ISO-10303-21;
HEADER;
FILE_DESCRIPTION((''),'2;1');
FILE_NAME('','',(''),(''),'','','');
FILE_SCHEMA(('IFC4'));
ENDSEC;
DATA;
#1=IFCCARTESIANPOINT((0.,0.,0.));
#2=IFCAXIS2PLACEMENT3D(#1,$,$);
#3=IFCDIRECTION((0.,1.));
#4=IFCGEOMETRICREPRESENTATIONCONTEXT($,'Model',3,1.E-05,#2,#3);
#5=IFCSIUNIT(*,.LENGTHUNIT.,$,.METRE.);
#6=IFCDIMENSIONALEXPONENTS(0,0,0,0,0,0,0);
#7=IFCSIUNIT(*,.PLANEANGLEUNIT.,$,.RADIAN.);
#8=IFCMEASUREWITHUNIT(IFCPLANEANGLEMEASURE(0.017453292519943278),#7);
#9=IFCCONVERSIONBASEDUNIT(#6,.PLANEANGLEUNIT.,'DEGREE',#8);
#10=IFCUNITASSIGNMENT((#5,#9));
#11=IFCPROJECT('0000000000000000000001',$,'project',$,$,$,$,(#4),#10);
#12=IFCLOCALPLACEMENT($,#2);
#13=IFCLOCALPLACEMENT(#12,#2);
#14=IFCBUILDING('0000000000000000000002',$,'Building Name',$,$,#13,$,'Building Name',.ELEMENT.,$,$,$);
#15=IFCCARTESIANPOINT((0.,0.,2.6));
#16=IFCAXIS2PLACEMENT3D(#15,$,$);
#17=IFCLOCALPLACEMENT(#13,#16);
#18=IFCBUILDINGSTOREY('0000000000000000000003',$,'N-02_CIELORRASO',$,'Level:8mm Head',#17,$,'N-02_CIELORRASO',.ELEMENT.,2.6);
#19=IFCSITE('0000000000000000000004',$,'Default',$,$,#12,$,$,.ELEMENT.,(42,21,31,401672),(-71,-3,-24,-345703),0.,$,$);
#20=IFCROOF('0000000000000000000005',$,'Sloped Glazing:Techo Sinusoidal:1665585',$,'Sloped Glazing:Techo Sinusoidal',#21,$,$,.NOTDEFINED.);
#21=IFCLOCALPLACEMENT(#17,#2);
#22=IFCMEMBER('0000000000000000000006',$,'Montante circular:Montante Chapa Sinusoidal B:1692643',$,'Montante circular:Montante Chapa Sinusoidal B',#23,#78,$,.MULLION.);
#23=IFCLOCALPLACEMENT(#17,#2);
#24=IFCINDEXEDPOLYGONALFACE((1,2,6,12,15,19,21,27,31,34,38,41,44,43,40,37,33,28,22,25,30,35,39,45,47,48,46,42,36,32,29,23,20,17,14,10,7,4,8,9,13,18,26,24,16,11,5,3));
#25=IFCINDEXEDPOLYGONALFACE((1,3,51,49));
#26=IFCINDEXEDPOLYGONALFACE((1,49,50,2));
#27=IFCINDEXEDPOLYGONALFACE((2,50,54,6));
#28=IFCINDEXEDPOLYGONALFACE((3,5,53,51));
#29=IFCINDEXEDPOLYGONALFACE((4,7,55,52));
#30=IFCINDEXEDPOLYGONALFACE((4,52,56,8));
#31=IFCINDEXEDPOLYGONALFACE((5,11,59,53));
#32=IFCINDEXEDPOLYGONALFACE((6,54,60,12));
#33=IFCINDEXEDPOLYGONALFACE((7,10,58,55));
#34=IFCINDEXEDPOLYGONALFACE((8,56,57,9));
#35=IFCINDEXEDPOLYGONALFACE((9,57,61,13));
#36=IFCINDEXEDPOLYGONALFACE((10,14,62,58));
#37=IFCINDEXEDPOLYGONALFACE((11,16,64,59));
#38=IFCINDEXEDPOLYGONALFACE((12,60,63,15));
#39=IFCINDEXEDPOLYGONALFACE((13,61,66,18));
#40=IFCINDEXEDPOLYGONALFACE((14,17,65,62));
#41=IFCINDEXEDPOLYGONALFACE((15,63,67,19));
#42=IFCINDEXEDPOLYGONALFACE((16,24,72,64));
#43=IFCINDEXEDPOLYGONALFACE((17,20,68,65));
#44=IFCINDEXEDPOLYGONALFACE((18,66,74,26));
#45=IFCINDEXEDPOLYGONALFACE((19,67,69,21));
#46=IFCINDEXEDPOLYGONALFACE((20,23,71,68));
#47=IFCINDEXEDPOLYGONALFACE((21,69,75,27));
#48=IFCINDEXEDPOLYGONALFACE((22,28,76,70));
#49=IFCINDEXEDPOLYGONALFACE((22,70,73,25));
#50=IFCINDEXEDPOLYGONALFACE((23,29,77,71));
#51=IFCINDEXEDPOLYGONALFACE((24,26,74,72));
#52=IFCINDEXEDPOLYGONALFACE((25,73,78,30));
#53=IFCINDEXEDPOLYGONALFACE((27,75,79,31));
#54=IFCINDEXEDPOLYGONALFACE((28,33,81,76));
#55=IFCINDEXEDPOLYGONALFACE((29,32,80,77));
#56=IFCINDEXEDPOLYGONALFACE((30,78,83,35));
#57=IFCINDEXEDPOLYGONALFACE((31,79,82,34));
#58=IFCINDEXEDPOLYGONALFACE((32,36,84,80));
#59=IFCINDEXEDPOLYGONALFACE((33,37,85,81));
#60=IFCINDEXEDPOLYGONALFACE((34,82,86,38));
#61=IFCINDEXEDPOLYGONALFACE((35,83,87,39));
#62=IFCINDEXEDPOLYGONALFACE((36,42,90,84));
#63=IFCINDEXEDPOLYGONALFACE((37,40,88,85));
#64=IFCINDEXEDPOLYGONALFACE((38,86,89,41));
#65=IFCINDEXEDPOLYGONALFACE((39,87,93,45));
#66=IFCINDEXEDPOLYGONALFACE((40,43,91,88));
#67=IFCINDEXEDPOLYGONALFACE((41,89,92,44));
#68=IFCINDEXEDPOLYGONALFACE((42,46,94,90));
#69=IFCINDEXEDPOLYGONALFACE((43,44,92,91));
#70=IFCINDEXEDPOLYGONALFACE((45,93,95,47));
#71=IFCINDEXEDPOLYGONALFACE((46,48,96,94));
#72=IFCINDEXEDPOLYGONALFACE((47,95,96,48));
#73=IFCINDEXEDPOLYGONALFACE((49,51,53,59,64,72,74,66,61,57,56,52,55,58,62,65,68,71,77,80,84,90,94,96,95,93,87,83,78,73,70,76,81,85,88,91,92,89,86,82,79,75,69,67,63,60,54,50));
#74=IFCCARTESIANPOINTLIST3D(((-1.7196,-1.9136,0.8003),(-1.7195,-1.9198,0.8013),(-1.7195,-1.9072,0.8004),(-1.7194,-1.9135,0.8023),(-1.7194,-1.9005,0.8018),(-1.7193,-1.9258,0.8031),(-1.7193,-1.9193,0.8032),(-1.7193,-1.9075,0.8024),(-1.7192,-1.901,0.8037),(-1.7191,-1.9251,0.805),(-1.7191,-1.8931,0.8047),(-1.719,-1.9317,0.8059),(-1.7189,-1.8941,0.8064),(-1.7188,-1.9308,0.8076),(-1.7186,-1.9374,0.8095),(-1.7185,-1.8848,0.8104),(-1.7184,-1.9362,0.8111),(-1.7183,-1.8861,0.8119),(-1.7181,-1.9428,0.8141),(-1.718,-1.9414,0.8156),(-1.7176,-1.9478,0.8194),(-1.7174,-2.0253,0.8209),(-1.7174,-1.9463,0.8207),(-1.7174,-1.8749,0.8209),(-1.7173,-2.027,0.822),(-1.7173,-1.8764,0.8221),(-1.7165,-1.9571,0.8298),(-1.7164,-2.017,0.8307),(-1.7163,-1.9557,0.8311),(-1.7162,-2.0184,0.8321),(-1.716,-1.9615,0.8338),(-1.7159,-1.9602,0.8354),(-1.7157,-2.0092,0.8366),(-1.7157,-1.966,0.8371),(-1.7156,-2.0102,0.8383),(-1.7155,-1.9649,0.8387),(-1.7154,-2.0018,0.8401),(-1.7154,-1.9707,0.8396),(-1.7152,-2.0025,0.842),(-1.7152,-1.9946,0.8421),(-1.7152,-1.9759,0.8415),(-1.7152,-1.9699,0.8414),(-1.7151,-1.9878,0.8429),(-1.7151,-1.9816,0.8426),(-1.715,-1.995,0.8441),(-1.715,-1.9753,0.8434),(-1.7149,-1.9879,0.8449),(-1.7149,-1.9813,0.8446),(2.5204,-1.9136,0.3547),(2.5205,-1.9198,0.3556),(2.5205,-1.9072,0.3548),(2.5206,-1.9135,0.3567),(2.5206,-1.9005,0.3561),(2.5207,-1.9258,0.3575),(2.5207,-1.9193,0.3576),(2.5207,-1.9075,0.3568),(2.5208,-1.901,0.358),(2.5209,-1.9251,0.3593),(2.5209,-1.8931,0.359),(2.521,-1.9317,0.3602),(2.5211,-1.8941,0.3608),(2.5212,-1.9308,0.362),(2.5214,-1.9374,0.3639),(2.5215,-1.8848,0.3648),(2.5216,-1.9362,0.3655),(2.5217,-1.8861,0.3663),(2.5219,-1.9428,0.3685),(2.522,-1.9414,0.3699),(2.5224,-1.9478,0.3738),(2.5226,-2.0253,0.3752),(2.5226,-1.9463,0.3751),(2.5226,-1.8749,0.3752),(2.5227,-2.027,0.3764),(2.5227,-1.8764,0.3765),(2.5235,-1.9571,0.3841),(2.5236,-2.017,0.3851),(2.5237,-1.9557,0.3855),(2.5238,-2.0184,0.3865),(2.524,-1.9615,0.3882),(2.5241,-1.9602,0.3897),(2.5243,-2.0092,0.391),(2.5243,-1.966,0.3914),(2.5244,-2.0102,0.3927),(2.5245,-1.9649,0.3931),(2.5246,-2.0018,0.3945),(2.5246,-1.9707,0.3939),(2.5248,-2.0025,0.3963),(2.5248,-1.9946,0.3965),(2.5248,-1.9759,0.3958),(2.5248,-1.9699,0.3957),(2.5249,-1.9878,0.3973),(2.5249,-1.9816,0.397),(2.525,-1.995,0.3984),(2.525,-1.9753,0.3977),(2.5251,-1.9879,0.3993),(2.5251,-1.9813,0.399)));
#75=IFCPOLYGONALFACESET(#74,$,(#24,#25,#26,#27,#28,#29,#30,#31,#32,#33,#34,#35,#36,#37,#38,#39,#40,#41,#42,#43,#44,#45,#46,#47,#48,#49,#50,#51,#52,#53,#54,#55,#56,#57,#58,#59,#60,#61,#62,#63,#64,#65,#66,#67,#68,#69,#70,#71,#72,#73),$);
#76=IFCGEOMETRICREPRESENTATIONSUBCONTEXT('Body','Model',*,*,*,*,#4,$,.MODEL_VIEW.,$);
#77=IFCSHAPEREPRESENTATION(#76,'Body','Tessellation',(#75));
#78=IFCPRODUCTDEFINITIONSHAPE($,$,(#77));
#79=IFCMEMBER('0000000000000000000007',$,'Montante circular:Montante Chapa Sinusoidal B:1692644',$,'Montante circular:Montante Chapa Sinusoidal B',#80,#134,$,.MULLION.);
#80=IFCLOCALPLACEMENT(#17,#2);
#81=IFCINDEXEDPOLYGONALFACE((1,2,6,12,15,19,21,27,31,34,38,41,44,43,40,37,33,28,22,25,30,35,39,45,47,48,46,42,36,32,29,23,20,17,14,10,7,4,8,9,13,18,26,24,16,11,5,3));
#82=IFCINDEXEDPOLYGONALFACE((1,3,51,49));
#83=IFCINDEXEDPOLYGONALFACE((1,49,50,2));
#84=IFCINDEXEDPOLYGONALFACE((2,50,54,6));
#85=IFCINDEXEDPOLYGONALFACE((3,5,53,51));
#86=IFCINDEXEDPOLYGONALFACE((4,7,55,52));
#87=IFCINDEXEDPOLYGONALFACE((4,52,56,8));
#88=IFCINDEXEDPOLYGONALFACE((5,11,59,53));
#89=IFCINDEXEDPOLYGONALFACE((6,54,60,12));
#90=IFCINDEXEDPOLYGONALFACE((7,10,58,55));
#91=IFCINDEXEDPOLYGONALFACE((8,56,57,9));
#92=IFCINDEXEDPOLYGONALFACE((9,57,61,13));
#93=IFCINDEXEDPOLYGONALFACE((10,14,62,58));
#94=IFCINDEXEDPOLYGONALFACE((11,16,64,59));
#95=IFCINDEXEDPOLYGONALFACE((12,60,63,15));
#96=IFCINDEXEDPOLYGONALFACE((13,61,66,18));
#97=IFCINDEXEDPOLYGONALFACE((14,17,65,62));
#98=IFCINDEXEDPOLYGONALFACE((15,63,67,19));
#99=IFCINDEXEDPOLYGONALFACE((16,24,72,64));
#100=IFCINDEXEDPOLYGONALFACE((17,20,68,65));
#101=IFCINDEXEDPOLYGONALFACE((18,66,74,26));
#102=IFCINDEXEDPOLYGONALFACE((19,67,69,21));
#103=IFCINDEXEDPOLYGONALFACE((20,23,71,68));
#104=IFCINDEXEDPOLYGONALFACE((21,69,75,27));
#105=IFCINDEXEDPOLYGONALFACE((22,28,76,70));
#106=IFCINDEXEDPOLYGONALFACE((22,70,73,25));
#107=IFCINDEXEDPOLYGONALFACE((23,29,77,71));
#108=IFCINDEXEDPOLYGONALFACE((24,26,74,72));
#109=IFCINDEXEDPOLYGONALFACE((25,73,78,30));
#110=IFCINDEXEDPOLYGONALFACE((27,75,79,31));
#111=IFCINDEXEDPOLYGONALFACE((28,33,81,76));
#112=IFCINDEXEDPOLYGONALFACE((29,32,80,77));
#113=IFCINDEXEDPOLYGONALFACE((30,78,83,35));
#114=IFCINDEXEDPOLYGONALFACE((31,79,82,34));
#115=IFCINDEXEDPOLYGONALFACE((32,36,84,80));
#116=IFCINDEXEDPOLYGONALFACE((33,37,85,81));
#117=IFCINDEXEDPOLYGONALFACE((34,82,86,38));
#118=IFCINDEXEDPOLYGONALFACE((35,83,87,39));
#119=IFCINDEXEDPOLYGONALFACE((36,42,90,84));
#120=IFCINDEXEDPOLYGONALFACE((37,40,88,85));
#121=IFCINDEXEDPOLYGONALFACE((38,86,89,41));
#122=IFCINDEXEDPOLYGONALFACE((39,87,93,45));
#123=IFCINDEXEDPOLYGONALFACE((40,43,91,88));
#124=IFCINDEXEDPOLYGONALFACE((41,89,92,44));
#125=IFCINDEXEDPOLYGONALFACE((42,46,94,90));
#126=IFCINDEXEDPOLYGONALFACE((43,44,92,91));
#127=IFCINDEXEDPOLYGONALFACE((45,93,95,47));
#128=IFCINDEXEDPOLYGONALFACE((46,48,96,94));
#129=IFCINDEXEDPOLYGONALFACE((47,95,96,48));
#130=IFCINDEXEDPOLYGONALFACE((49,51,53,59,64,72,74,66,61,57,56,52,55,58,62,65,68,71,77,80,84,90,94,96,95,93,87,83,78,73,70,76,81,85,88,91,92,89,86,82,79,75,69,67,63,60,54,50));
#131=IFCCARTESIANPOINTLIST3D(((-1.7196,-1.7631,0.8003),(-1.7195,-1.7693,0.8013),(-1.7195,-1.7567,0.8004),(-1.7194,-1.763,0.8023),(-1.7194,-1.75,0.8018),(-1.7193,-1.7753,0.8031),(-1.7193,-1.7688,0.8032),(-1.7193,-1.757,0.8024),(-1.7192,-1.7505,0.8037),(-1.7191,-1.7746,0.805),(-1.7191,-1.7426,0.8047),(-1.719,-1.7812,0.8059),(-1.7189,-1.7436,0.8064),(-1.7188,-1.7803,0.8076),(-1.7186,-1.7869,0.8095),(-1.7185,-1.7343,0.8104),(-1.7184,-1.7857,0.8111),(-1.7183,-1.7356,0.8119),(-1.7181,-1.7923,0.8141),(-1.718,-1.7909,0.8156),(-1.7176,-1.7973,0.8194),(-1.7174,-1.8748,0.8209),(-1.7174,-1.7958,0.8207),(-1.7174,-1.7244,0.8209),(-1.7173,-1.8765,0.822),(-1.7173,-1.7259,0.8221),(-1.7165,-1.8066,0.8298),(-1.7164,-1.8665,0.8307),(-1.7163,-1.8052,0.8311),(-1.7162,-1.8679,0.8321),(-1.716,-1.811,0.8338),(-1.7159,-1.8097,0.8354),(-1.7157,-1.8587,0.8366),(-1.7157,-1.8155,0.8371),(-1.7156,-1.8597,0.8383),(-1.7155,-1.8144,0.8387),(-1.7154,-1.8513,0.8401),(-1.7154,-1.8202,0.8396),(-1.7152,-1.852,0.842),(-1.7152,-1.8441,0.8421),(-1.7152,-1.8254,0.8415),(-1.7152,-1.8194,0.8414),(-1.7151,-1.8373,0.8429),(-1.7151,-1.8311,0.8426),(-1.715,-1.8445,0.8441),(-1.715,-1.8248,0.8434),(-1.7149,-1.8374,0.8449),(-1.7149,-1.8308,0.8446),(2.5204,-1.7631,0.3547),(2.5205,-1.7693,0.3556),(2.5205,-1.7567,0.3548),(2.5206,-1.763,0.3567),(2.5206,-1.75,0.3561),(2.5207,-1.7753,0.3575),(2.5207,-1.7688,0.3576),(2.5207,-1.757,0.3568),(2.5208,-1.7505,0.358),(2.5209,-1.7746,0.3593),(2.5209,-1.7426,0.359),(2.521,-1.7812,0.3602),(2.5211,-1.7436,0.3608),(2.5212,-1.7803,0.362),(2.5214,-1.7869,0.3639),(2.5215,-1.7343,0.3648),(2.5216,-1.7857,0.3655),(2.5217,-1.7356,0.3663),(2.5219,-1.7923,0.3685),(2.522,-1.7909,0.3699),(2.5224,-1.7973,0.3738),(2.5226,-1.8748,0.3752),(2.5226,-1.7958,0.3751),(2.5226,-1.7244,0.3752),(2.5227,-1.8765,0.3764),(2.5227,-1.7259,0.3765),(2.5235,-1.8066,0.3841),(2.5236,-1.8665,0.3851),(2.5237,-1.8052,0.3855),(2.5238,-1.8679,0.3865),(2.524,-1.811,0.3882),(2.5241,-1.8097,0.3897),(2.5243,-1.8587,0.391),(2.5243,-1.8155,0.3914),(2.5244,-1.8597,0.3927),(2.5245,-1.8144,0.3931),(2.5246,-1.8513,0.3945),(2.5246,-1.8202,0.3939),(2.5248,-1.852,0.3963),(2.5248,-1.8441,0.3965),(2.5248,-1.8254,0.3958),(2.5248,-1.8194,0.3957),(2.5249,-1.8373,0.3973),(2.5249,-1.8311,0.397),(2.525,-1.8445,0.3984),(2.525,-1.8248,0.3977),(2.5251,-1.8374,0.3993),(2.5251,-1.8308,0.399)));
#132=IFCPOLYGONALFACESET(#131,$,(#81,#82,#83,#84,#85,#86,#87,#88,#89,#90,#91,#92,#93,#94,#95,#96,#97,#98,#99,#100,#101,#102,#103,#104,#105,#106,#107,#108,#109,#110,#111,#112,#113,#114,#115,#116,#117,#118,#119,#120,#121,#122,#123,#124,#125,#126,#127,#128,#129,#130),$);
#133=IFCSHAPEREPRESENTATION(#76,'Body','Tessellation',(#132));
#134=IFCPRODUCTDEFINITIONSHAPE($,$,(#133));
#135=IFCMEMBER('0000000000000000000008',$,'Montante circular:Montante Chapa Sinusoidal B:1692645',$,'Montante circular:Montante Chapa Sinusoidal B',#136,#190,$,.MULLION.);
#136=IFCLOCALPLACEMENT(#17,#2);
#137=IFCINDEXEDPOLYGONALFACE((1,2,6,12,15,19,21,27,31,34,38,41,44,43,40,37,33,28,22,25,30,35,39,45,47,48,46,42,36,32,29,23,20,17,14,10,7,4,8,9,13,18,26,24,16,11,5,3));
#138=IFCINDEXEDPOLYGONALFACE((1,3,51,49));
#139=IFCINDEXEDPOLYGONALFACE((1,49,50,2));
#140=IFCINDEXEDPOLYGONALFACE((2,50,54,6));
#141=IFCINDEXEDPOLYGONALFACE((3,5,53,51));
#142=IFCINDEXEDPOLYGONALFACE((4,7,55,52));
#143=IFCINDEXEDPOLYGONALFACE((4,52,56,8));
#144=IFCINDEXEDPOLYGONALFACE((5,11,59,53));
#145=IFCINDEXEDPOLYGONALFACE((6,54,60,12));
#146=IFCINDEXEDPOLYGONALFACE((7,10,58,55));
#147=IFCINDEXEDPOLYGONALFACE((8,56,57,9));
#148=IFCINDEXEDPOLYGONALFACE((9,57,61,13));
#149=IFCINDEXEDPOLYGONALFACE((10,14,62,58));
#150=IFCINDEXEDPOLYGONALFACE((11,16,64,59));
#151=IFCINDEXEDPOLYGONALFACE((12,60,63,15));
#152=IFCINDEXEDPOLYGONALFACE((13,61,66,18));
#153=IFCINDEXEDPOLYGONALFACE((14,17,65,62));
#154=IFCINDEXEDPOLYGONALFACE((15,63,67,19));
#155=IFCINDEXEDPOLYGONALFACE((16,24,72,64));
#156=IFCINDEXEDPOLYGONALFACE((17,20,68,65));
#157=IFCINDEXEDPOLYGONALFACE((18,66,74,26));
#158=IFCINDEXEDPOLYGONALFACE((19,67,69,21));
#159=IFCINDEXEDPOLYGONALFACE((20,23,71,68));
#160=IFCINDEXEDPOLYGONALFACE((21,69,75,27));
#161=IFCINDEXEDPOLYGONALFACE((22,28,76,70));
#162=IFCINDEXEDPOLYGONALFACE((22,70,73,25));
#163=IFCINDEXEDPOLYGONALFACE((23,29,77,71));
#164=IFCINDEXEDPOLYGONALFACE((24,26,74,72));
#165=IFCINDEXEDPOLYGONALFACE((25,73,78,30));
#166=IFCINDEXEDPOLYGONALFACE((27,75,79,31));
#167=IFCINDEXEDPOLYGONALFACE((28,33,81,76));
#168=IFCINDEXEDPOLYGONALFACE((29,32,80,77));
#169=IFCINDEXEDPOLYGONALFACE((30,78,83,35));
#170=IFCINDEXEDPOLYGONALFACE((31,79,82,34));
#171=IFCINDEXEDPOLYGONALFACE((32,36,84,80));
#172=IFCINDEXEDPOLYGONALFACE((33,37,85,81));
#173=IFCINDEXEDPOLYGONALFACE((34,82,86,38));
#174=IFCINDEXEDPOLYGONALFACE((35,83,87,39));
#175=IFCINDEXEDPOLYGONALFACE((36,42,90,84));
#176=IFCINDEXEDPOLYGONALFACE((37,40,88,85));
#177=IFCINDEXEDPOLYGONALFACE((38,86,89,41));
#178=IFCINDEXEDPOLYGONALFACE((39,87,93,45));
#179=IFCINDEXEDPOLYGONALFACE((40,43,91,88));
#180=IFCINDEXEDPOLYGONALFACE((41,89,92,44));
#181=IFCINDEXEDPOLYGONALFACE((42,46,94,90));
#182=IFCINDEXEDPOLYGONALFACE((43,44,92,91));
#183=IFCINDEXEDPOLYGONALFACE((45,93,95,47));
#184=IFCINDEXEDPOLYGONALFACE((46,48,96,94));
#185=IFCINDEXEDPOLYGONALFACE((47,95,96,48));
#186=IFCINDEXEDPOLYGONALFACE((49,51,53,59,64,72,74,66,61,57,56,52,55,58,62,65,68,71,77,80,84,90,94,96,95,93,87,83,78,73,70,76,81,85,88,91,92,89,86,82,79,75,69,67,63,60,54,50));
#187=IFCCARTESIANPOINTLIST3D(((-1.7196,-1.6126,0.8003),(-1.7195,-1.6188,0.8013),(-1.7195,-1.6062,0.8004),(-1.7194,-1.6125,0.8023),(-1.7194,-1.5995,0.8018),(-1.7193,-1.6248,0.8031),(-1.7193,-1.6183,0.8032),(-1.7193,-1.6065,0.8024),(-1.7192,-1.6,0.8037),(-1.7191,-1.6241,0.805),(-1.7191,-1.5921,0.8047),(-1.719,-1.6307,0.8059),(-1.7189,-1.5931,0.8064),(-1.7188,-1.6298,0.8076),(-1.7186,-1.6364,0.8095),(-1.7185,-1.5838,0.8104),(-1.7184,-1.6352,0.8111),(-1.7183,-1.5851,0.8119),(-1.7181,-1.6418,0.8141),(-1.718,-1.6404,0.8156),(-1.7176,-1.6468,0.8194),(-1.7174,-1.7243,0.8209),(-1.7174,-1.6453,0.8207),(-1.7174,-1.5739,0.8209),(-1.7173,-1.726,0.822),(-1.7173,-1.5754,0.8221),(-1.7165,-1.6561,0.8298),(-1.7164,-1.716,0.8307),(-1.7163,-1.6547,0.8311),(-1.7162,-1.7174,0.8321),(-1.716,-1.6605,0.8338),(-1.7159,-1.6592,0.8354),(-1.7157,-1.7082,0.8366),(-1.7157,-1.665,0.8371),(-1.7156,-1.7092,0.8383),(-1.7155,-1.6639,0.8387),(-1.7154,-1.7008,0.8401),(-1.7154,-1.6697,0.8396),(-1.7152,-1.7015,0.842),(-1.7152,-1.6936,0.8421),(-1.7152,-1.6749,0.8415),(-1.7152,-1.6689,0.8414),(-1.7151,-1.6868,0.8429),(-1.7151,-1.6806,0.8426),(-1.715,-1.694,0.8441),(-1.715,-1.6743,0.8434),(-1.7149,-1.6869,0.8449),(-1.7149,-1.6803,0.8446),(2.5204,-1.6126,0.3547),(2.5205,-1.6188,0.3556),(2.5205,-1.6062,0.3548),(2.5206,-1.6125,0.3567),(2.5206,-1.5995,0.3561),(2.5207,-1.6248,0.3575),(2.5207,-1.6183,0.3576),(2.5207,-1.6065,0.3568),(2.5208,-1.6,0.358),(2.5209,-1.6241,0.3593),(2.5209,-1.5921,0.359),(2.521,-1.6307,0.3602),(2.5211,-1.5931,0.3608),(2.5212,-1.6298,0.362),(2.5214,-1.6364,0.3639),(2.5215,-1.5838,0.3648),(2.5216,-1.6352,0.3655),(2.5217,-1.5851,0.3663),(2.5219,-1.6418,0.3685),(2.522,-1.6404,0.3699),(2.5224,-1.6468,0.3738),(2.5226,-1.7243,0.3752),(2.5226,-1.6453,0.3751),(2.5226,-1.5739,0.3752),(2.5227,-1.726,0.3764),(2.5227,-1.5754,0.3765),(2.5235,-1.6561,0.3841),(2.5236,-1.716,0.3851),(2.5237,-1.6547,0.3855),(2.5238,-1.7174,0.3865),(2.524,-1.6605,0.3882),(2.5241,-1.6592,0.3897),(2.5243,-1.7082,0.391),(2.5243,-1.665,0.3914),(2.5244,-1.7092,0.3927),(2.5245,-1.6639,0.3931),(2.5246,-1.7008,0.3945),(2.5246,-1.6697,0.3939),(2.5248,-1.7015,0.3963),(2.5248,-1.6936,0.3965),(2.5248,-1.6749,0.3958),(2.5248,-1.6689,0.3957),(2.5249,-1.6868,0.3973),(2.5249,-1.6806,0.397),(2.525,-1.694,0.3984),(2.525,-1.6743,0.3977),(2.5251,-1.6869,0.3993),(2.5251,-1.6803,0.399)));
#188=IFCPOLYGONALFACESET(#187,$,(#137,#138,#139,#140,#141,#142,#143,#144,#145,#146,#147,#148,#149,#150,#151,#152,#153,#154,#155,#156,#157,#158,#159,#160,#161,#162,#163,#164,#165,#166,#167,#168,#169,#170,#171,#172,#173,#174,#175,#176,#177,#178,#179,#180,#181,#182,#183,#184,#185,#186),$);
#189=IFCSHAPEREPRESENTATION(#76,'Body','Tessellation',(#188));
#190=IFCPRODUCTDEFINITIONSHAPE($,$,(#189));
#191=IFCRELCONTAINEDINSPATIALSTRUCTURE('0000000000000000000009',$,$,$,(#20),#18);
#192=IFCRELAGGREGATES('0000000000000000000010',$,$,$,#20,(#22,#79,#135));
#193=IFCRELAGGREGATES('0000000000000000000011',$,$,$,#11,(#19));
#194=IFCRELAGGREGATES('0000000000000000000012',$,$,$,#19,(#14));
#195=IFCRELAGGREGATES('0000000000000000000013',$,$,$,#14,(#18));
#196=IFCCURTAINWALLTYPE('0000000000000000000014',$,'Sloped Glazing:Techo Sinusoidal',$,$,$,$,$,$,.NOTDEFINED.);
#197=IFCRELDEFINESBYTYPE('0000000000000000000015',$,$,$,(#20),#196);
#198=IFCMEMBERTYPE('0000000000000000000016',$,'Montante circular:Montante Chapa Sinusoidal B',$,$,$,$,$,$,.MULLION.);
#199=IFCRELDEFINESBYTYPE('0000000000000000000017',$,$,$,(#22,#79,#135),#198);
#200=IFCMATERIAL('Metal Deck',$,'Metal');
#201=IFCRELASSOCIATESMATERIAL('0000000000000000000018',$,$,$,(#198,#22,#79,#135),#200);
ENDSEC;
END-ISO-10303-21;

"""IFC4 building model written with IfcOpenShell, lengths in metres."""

from ifc_helpers import new_model, entity, si_unit, converted_unit, direction, frame, origin, place, context, subcontext, project, spatial, indexed_curve, outline, extrude, source, transform, mapped, material, type_object, type_shapes, element, aggregate, save


model = new_model("IFC4")

# Units and contexts
model_context = context("Model", 3, precision=1e-05, world=origin(), true_north=direction((0.0, 1.0)))
body_context = subcontext(model_context, "Body", "Model", "MODEL_VIEW")
ifc_project = project(units=[si_unit("LENGTHUNIT", "METRE"), converted_unit("PLANEANGLEUNIT", "DEGREE", entity("IfcPlaneAngleMeasure", 0.017453292519943278), si_unit("PLANEANGLEUNIT", "RADIAN"), dimensions=[0, 0, 0, 0, 0, 0, 0])], contexts=[model_context])

# Site, building, storey
site_placement = place(None, origin())
site = spatial("IfcSite", under=ifc_project, at=site_placement, Name="Default", CompositionType="ELEMENT", RefLatitude=(42, 21, 31, 401672), RefLongitude=(-71, -3, -24, -345703), RefElevation=0.0)
building_placement = place(site_placement, origin())
building = spatial("IfcBuilding", under=site, at=building_placement, Name="Building Name", LongName="Building Name", CompositionType="ELEMENT")
storey_placement = place(building_placement, frame((0.0, 0.0, 2.6)))
storey = spatial("IfcBuildingStorey", under=building, at=storey_placement, Name="N-02_CIELORRASO", ObjectType="Level:8mm Head", LongName="N-02_CIELORRASO", CompositionType="ELEMENT", Elevation=2.6)

# Roof, members
curtain_wall_type = type_object("IfcCurtainWallType", Name="Sloped Glazing:Techo Sinusoidal", PredefinedType="NOTDEFINED")
roof_placement = place(storey_placement, frame((0.0, 0.0, -2.6)))
roof = element("IfcRoof", 1, at=roof_placement, inside=storey, type_object=curtain_wall_type, Name="Sloped Glazing:Techo Sinusoidal:1665585", ObjectType="Sloped Glazing:Techo Sinusoidal", PredefinedType="NOTDEFINED")
ifc_material_1 = material(Name="Metal Deck", Category="Metal")
member_type = type_object("IfcMemberType", Name="Montante circular:Montante Chapa Sinusoidal B", PredefinedType="MULLION", material=ifc_material_1)
shared_shape_1 = source(origin(), body_context, "Body", "SweptSolid", [
    extrude(outline(indexed_curve([(0.0595, -0.0443), (0.0615, -0.0443), (0.0603, -0.031), (0.0572, -0.0213), (0.053, -0.0138), (0.0481, -0.0078), (0.0427, -0.003), (0.0372, 0.0005), (0.0315, 0.0029), (0.0259, 0.0044), (0.0203, 0.0051), (0.0146, 0.005), (0.0084, 0.0041), (-0.0053, 0.0009), (-0.0123, -0.0005), (-0.0191, -0.0012), (-0.0256, -0.001), (-0.0317, 0.0001), (-0.0375, 0.0019), (-0.0428, 0.0046), (-0.0477, 0.0081), (-0.0522, 0.0128), (-0.0563, 0.0191), (-0.0597, 0.0282), (-0.0617, 0.0421), (-0.0637, 0.042), (-0.0616, 0.0277), (-0.0581, 0.0182), (-0.0537, 0.0116), (-0.049, 0.0066), (-0.0438, 0.0028), (-0.0382, 0.0001), (-0.0322, -0.0019), (-0.0258, -0.003), (-0.019, -0.0032), (-0.012, -0.0025), (-0.0048, -0.0011), (0.0088, 0.0021), (0.0147, 0.003), (0.0202, 0.0031), (0.0255, 0.0024), (0.0309, 0.001), (0.0362, -0.0013), (0.0415, -0.0046), (0.0466, -0.0092), (0.0513, -0.0149), (0.0554, -0.0221), (0.0584, -0.0314), (0.0595, -0.0443)], self_intersect=False)), frame((-0.007, 0.0228, -4.2634), z_axis=(0.0, 0.0, 1.0), x_axis=(-0.819152, -0.573576, 0.0)), (0.0, 0.0, 1.0), 4.2634),
])
type_shapes(member_type, [shared_shape_1])
member_1_placement = place(roof_placement, frame((-1.7148, -1.9441, 3.4456), z_axis=(-0.994522, 0.0, 0.104528), x_axis=(0.0, 1.0, 0.0)))
member_1 = element("IfcMember", 2, at=member_1_placement, type_object=member_type, material=ifc_material_1, Name="Montante circular:Montante Chapa Sinusoidal B:1692643", ObjectType="Montante circular:Montante Chapa Sinusoidal B", PredefinedType="MULLION", context=body_context, shape_type="MappedRepresentation", body=[
    mapped(shared_shape_1, transform((0.0, 0.0, 0.0), scale=1.0)),
])
member_2_placement = place(roof_placement, frame((-1.7148, -1.7936, 3.4456), z_axis=(-0.994522, 0.0, 0.104528), x_axis=(0.0, 1.0, 0.0)))
member_2 = element("IfcMember", 3, at=member_2_placement, type_object=member_type, material=ifc_material_1, Name="Montante circular:Montante Chapa Sinusoidal B:1692644", ObjectType="Montante circular:Montante Chapa Sinusoidal B", PredefinedType="MULLION", context=body_context, shape_type="MappedRepresentation", body=[
    mapped(shared_shape_1, transform((0.0, 0.0, 0.0), scale=1.0)),
])
member_3_placement = place(roof_placement, frame((-1.7148, -1.6431, 3.4456), z_axis=(-0.994522, 0.0, 0.104528), x_axis=(0.0, 1.0, 0.0)))
member_3 = element("IfcMember", 4, at=member_3_placement, type_object=member_type, material=ifc_material_1, Name="Montante circular:Montante Chapa Sinusoidal B:1692645", ObjectType="Montante circular:Montante Chapa Sinusoidal B", PredefinedType="MULLION", context=body_context, shape_type="MappedRepresentation", body=[
    mapped(shared_shape_1, transform((0.0, 0.0, 0.0), scale=1.0)),
])
aggregate(roof, [member_1, member_2, member_3])

save(model, "model.ifc")
